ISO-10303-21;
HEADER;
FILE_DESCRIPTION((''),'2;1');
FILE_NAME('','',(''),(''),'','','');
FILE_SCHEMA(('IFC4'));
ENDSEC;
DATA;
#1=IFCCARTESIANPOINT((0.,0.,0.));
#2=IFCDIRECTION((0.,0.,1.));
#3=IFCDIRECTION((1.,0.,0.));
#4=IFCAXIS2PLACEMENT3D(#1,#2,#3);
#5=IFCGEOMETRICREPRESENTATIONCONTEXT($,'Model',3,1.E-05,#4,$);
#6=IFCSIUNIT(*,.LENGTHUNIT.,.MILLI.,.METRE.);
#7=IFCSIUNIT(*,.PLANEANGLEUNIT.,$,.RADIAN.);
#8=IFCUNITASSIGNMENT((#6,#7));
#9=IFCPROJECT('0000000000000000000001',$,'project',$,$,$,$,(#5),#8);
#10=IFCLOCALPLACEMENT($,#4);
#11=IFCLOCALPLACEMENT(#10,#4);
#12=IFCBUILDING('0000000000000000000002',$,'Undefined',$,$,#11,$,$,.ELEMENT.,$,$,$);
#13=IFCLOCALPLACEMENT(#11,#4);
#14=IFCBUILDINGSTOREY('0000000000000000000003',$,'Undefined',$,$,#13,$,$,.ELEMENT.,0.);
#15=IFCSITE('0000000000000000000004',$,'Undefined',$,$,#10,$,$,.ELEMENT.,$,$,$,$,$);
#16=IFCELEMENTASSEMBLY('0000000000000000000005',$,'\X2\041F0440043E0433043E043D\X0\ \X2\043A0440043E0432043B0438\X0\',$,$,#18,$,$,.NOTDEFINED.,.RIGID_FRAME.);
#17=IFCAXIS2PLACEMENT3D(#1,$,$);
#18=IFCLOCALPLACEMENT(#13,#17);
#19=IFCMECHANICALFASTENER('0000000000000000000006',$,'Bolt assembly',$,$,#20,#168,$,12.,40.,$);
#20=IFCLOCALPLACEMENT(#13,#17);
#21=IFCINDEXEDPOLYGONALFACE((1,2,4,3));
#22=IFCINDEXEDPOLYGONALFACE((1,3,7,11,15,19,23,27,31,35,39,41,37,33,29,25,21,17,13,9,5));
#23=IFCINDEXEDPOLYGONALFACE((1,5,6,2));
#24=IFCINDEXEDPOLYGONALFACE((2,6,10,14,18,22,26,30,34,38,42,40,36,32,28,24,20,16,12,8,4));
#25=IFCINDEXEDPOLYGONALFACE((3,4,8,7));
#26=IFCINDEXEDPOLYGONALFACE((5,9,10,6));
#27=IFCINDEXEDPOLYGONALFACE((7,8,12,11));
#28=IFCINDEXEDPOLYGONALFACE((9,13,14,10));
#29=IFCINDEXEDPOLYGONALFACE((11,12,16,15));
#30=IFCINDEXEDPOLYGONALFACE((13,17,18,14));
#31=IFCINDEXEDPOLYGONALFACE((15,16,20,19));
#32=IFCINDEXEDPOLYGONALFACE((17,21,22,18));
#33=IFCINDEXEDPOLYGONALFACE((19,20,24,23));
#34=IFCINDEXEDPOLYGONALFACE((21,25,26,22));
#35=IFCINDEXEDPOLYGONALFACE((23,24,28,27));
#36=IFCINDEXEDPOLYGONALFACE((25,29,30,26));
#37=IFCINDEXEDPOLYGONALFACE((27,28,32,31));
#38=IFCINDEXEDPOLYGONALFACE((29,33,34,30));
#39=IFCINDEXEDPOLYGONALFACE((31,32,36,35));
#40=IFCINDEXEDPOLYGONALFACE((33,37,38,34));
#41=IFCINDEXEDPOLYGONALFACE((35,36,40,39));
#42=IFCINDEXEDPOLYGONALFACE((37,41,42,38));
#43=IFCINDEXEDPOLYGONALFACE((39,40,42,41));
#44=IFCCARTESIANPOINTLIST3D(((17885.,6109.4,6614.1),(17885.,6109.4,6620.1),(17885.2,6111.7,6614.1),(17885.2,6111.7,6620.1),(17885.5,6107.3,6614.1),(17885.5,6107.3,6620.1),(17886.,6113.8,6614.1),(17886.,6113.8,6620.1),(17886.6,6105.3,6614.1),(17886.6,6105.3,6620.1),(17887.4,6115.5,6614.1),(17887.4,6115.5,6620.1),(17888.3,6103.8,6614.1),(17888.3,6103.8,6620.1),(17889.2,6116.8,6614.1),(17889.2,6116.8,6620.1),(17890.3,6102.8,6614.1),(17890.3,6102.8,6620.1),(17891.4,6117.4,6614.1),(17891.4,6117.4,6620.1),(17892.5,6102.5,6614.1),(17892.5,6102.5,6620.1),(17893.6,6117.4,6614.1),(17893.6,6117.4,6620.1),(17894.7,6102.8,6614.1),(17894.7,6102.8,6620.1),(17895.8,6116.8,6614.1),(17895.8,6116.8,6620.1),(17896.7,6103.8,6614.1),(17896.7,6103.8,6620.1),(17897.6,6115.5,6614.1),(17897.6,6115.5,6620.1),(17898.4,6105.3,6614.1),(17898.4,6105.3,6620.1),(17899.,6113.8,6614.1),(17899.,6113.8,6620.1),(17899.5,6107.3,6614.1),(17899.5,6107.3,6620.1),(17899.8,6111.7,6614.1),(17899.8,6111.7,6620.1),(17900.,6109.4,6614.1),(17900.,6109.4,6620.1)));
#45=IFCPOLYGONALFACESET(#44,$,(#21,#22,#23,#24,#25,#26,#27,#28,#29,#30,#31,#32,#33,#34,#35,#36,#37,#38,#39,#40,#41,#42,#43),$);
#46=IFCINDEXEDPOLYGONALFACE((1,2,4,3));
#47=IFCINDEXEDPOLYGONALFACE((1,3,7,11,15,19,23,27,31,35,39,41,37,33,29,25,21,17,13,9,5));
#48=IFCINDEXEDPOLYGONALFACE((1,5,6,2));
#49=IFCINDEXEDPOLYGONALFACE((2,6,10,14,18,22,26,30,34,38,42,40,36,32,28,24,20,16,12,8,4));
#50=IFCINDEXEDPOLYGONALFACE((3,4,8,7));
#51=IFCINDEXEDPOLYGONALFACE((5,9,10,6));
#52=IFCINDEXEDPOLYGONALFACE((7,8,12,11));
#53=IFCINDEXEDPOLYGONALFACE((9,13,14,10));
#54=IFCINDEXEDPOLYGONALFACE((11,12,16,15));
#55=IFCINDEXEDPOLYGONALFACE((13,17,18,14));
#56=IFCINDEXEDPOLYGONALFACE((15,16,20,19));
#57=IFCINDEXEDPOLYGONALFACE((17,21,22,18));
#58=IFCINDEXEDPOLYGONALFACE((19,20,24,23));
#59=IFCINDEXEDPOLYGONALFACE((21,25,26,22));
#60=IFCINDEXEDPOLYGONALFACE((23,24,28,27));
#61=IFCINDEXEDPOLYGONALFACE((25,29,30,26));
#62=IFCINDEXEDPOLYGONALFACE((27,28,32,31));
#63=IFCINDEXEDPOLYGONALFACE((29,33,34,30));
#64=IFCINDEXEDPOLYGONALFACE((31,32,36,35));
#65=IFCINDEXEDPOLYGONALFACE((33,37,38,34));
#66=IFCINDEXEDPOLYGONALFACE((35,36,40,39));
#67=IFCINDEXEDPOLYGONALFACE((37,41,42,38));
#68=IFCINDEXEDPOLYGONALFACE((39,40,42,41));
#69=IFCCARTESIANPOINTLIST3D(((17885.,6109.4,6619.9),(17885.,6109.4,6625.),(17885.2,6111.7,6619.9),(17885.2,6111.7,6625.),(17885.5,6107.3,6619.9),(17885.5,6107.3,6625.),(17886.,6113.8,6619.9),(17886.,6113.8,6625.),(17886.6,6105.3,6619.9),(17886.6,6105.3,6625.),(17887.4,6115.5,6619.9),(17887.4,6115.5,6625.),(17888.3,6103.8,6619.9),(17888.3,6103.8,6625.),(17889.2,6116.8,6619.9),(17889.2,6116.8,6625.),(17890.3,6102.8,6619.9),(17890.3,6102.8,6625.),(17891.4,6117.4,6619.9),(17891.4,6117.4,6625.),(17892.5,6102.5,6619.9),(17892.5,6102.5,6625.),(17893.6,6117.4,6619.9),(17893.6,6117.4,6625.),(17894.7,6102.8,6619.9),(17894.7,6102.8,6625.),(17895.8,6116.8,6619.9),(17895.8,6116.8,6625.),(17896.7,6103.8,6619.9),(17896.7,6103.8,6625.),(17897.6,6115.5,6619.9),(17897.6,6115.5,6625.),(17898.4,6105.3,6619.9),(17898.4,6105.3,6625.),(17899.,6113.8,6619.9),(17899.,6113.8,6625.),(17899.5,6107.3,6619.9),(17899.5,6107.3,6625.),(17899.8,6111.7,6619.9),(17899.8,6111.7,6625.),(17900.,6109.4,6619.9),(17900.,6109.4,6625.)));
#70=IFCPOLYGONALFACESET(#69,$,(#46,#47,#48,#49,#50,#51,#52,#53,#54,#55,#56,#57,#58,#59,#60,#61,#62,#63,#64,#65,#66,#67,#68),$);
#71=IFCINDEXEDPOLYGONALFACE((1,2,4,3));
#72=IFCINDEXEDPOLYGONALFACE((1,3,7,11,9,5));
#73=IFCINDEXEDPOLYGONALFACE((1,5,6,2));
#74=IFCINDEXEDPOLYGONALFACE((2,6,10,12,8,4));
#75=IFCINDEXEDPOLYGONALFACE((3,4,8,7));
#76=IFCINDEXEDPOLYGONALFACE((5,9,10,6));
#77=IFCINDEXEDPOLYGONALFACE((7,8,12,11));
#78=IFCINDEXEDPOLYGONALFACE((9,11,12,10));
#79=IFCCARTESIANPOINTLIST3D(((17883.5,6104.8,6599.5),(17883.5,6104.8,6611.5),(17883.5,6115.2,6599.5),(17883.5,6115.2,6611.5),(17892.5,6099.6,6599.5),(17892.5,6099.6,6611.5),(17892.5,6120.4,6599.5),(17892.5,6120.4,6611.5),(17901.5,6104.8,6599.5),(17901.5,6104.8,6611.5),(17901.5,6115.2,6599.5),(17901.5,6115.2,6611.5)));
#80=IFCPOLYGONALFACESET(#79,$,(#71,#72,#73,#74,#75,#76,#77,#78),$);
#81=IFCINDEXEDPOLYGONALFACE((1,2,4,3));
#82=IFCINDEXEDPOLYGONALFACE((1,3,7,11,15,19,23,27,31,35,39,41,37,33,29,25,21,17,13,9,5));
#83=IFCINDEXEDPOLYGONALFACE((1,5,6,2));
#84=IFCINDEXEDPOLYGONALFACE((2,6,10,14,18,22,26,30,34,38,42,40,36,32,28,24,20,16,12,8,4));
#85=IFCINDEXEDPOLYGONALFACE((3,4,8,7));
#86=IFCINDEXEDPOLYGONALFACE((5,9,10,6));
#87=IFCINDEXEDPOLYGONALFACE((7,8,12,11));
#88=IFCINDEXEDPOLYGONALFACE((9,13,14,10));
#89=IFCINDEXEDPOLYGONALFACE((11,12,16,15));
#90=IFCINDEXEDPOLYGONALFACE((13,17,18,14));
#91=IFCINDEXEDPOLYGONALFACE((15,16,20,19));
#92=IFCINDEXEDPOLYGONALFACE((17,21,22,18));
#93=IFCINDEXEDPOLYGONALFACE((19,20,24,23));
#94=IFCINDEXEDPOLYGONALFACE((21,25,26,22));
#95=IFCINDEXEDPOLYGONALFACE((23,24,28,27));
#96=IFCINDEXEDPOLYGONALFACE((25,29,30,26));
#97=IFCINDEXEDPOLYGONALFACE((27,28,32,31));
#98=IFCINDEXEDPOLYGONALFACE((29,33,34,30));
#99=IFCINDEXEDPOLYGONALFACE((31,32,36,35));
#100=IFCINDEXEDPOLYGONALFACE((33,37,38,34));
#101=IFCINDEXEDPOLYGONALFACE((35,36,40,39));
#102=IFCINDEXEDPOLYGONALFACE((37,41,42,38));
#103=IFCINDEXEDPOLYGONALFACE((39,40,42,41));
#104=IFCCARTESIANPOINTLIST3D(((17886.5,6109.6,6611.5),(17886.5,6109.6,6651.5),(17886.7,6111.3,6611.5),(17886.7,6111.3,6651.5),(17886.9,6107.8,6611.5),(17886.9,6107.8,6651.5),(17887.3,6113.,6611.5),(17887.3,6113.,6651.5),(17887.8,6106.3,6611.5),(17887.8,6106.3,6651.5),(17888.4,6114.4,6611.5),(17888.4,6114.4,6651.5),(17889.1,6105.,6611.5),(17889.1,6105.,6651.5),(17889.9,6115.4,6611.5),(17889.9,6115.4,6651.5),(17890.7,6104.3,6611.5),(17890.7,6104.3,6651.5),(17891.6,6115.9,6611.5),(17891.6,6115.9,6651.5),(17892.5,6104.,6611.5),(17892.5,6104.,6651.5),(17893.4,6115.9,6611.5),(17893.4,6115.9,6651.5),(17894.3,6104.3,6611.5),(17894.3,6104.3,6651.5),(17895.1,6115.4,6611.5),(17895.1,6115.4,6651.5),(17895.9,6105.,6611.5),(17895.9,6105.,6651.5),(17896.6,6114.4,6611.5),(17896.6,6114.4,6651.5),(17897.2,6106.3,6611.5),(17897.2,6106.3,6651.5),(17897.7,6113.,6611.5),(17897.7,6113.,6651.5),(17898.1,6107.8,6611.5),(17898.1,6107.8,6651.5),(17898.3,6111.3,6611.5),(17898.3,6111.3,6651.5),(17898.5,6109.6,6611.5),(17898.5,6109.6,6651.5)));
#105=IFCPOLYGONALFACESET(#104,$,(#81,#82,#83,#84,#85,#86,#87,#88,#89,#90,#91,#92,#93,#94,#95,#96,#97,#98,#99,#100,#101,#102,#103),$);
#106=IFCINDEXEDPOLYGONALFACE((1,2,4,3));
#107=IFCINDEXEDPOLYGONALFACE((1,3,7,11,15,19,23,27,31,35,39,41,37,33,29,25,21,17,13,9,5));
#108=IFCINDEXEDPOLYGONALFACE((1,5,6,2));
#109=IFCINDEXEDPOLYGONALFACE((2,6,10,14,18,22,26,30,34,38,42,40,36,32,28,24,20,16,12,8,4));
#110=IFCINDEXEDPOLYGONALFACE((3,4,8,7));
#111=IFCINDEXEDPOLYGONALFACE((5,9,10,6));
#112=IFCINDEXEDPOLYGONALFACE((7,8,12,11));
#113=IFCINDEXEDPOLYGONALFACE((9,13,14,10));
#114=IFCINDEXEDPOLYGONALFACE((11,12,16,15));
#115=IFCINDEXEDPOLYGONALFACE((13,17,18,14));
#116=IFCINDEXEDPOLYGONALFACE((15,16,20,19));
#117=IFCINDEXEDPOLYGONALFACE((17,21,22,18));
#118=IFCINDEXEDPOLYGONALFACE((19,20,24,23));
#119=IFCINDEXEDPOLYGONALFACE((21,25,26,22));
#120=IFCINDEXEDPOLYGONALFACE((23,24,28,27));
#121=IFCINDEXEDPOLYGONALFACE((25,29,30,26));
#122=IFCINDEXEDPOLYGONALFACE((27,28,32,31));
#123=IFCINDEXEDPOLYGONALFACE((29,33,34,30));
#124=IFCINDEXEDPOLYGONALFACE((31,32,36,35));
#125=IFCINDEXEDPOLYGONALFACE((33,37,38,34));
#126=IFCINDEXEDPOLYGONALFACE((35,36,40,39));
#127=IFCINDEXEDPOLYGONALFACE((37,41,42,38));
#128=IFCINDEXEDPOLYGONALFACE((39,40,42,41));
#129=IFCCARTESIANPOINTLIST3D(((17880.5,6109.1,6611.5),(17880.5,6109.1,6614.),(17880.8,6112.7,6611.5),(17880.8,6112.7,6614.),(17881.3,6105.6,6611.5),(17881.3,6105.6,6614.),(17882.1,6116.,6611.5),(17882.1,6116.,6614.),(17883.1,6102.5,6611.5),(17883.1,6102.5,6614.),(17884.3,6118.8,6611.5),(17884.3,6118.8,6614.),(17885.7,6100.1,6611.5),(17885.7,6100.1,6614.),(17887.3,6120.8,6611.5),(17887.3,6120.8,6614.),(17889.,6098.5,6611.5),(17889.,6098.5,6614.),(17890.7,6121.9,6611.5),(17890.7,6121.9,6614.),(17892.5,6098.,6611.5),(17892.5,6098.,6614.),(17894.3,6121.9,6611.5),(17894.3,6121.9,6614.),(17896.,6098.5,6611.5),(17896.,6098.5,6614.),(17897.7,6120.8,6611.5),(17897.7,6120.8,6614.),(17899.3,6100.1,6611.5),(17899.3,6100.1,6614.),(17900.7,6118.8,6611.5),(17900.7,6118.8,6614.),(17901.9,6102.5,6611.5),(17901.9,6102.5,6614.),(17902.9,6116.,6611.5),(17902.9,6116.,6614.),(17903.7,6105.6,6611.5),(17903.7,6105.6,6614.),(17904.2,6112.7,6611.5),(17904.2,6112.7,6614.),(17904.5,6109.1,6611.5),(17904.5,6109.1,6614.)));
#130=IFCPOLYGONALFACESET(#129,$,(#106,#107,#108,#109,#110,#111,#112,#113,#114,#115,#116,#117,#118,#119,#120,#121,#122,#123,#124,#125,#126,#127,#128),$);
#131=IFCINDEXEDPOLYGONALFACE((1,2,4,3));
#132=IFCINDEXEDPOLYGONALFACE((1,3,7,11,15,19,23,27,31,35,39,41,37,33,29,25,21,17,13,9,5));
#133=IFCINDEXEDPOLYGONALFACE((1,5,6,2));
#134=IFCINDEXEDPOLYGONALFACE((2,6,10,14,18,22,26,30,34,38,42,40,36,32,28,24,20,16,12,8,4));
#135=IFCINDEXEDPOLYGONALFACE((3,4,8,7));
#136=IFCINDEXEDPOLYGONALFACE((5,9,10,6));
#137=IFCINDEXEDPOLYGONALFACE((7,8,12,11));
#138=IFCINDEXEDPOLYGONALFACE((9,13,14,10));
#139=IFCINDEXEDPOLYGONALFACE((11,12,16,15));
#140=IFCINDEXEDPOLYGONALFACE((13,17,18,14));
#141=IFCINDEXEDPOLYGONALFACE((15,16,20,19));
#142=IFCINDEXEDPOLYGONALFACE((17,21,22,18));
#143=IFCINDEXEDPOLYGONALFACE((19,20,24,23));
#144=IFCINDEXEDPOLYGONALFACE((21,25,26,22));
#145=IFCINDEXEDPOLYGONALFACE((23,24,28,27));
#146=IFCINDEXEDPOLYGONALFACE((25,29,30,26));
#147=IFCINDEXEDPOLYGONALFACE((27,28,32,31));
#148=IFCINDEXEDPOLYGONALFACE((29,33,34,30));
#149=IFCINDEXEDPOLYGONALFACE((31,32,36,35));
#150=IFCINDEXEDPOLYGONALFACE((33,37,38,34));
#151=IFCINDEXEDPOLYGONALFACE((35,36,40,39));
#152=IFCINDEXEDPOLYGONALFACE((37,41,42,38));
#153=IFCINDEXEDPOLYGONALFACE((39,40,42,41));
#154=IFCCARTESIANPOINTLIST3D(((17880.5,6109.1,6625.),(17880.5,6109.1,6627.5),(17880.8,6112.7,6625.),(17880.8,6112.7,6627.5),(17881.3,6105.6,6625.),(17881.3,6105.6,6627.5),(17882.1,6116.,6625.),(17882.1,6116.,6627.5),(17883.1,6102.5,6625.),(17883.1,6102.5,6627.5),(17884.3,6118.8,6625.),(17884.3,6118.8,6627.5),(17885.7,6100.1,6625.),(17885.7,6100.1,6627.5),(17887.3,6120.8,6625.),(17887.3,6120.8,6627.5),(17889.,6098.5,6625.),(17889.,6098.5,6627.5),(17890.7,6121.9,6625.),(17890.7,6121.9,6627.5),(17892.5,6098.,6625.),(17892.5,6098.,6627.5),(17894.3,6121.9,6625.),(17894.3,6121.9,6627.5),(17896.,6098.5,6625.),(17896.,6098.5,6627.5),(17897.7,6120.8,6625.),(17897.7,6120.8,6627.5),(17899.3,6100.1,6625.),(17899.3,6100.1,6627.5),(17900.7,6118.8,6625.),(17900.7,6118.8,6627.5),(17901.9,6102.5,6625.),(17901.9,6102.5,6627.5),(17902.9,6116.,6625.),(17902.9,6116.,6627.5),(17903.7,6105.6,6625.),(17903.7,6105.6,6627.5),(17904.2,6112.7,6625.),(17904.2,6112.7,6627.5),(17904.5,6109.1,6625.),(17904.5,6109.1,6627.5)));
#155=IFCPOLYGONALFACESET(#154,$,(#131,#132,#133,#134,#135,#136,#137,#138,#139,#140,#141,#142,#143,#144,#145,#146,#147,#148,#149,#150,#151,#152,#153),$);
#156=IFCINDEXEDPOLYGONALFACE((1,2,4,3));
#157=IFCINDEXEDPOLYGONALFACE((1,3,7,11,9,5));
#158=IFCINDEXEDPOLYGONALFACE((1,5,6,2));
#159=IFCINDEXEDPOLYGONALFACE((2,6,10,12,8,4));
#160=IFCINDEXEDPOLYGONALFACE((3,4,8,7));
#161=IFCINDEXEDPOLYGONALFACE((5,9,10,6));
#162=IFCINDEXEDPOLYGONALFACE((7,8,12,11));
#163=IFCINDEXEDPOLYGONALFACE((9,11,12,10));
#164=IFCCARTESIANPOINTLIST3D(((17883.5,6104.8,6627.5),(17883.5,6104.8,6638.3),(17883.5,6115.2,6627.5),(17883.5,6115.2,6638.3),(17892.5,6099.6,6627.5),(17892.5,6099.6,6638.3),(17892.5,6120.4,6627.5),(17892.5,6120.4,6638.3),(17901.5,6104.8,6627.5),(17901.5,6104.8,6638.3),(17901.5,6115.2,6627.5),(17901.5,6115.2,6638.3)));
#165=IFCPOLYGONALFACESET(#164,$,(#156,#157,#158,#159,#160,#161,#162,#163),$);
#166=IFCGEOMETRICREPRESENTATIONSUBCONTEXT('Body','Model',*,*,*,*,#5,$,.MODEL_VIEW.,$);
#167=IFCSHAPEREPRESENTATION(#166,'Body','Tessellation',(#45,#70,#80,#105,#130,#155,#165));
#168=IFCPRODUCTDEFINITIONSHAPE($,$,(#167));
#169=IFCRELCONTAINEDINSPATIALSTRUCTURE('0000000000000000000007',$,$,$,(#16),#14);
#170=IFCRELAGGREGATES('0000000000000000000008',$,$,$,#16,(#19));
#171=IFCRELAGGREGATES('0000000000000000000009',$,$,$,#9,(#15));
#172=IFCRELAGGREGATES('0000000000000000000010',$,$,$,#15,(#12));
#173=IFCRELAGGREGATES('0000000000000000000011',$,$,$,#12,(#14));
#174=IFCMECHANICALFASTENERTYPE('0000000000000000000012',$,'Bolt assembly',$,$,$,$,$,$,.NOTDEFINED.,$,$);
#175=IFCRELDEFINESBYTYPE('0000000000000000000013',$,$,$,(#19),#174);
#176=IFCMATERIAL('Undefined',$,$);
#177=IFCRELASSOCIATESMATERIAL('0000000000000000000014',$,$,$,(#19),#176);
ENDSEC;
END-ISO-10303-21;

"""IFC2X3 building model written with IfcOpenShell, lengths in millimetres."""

from ifc_helpers import new_model, si_unit, frame, origin_with_axes, origin_2d_with_axis, place, context, subcontext, project, spatial, polyline, circle, outline, extrude, source, transform, mapped, material, type_object, element, aggregate, save


model = new_model("IFC2X3")

# Units and contexts
model_context = context("Model", 3, precision=1e-05, world=origin_with_axes())
body_context = subcontext(model_context, "Body", "Model", "MODEL_VIEW")
ifc_project = project(units=[si_unit("LENGTHUNIT", "METRE", prefix="MILLI"), si_unit("PLANEANGLEUNIT", "RADIAN")], contexts=[model_context])

# Site, building, storey
site_placement = place(None, origin_with_axes())
site = spatial("IfcSite", under=ifc_project, at=site_placement, Name="Undefined", CompositionType="ELEMENT")
building_placement = place(site_placement, origin_with_axes())
building = spatial("IfcBuilding", under=site, at=building_placement, Name="Undefined", CompositionType="ELEMENT")
storey_placement = place(building_placement, origin_with_axes())
storey = spatial("IfcBuildingStorey", under=building, at=storey_placement, Name="Undefined", CompositionType="ELEMENT", Elevation=0.0)

# Element assembly
assembly_1_placement = place(storey_placement, origin_with_axes())
assembly_1 = element("IfcElementAssembly", 1, at=assembly_1_placement, inside=storey, Name="Прогон кровли", AssemblyPlace="NOTDEFINED", PredefinedType="RIGID_FRAME")

# Mechanical fastener
ifc_material_1 = material(Name="Undefined")
mechanical_fastener_type = type_object("IfcMechanicalFastenerType", Name="Bolt assembly")
shared_shape_1 = source(origin_with_axes(), body_context, "Body", "SweptSolid", [
    extrude(circle(Radius=7.5, at=origin_2d_with_axis()), frame((0.0, -5.9, 0.0), z_axis=(0.0, 1.0, 0.0), x_axis=(1.0, 0.0, 0.0)), (0.0, 0.0, 1.0), 6.0),
    extrude(circle(Radius=7.5, at=origin_2d_with_axis()), frame((0.0, -0.1, 0.0), z_axis=(0.0, 1.0, 0.0), x_axis=(1.0, 0.0, 0.0)), (0.0, 0.0, 1.0), 5.1),
    extrude(outline(polyline([(10.4, 0.0), (5.2, 9.0), (-5.2, 9.0), (-10.4, 0.0), (-5.2, -9.0), (5.2, -9.0), (10.4, 0.0)])), frame((0.0, -20.5, 0.0), z_axis=(0.0, 1.0, 0.0), x_axis=(1.0, 0.0, 0.0)), (0.0, 0.0, 1.0), 12.0),
    extrude(circle(Radius=6.0, at=origin_2d_with_axis()), frame((0.0, -8.5, 0.0), z_axis=(0.0, 1.0, 0.0), x_axis=(1.0, 0.0, 0.0)), (0.0, 0.0, 1.0), 40.0),
    extrude(circle(Radius=12.0, at=origin_2d_with_axis()), frame((0.0, -8.5, 0.0), z_axis=(0.0, 1.0, 0.0), x_axis=(1.0, 0.0, 0.0)), (0.0, 0.0, 1.0), 2.5),
    extrude(circle(Radius=12.0, at=origin_2d_with_axis()), frame((0.0, 5.0, 0.0), z_axis=(0.0, 1.0, 0.0), x_axis=(1.0, 0.0, 0.0)), (0.0, 0.0, 1.0), 2.5),
    extrude(outline(polyline([(10.4, 0.0), (5.2, 9.0), (-5.2, 9.0), (-10.4, 0.0), (-5.2, -9.0), (5.2, -9.0), (10.4, 0.0)])), frame((0.0, 7.5, 0.0), z_axis=(0.0, 1.0, 0.0), x_axis=(1.0, 0.0, 0.0)), (0.0, 0.0, 1.0), 10.8),
])
mechanical_fastener_1_placement = place(assembly_1_placement, frame((17892.5, 6110.0, 6620.0), z_axis=(-1.0, 0.0, 0.0), x_axis=(0.0, -1.0, 0.0)))
mechanical_fastener_1 = element("IfcMechanicalFastener", 2, at=mechanical_fastener_1_placement, type_object=mechanical_fastener_type, material=ifc_material_1, Name="Bolt assembly", NominalDiameter=12.0, NominalLength=40.0, context=body_context, shape_type="MappedRepresentation", body=[
    mapped(shared_shape_1, transform((0.0, 0.0, 0.0))),
])
aggregate(assembly_1, [mechanical_fastener_1])

save(model, "model.ifc")
